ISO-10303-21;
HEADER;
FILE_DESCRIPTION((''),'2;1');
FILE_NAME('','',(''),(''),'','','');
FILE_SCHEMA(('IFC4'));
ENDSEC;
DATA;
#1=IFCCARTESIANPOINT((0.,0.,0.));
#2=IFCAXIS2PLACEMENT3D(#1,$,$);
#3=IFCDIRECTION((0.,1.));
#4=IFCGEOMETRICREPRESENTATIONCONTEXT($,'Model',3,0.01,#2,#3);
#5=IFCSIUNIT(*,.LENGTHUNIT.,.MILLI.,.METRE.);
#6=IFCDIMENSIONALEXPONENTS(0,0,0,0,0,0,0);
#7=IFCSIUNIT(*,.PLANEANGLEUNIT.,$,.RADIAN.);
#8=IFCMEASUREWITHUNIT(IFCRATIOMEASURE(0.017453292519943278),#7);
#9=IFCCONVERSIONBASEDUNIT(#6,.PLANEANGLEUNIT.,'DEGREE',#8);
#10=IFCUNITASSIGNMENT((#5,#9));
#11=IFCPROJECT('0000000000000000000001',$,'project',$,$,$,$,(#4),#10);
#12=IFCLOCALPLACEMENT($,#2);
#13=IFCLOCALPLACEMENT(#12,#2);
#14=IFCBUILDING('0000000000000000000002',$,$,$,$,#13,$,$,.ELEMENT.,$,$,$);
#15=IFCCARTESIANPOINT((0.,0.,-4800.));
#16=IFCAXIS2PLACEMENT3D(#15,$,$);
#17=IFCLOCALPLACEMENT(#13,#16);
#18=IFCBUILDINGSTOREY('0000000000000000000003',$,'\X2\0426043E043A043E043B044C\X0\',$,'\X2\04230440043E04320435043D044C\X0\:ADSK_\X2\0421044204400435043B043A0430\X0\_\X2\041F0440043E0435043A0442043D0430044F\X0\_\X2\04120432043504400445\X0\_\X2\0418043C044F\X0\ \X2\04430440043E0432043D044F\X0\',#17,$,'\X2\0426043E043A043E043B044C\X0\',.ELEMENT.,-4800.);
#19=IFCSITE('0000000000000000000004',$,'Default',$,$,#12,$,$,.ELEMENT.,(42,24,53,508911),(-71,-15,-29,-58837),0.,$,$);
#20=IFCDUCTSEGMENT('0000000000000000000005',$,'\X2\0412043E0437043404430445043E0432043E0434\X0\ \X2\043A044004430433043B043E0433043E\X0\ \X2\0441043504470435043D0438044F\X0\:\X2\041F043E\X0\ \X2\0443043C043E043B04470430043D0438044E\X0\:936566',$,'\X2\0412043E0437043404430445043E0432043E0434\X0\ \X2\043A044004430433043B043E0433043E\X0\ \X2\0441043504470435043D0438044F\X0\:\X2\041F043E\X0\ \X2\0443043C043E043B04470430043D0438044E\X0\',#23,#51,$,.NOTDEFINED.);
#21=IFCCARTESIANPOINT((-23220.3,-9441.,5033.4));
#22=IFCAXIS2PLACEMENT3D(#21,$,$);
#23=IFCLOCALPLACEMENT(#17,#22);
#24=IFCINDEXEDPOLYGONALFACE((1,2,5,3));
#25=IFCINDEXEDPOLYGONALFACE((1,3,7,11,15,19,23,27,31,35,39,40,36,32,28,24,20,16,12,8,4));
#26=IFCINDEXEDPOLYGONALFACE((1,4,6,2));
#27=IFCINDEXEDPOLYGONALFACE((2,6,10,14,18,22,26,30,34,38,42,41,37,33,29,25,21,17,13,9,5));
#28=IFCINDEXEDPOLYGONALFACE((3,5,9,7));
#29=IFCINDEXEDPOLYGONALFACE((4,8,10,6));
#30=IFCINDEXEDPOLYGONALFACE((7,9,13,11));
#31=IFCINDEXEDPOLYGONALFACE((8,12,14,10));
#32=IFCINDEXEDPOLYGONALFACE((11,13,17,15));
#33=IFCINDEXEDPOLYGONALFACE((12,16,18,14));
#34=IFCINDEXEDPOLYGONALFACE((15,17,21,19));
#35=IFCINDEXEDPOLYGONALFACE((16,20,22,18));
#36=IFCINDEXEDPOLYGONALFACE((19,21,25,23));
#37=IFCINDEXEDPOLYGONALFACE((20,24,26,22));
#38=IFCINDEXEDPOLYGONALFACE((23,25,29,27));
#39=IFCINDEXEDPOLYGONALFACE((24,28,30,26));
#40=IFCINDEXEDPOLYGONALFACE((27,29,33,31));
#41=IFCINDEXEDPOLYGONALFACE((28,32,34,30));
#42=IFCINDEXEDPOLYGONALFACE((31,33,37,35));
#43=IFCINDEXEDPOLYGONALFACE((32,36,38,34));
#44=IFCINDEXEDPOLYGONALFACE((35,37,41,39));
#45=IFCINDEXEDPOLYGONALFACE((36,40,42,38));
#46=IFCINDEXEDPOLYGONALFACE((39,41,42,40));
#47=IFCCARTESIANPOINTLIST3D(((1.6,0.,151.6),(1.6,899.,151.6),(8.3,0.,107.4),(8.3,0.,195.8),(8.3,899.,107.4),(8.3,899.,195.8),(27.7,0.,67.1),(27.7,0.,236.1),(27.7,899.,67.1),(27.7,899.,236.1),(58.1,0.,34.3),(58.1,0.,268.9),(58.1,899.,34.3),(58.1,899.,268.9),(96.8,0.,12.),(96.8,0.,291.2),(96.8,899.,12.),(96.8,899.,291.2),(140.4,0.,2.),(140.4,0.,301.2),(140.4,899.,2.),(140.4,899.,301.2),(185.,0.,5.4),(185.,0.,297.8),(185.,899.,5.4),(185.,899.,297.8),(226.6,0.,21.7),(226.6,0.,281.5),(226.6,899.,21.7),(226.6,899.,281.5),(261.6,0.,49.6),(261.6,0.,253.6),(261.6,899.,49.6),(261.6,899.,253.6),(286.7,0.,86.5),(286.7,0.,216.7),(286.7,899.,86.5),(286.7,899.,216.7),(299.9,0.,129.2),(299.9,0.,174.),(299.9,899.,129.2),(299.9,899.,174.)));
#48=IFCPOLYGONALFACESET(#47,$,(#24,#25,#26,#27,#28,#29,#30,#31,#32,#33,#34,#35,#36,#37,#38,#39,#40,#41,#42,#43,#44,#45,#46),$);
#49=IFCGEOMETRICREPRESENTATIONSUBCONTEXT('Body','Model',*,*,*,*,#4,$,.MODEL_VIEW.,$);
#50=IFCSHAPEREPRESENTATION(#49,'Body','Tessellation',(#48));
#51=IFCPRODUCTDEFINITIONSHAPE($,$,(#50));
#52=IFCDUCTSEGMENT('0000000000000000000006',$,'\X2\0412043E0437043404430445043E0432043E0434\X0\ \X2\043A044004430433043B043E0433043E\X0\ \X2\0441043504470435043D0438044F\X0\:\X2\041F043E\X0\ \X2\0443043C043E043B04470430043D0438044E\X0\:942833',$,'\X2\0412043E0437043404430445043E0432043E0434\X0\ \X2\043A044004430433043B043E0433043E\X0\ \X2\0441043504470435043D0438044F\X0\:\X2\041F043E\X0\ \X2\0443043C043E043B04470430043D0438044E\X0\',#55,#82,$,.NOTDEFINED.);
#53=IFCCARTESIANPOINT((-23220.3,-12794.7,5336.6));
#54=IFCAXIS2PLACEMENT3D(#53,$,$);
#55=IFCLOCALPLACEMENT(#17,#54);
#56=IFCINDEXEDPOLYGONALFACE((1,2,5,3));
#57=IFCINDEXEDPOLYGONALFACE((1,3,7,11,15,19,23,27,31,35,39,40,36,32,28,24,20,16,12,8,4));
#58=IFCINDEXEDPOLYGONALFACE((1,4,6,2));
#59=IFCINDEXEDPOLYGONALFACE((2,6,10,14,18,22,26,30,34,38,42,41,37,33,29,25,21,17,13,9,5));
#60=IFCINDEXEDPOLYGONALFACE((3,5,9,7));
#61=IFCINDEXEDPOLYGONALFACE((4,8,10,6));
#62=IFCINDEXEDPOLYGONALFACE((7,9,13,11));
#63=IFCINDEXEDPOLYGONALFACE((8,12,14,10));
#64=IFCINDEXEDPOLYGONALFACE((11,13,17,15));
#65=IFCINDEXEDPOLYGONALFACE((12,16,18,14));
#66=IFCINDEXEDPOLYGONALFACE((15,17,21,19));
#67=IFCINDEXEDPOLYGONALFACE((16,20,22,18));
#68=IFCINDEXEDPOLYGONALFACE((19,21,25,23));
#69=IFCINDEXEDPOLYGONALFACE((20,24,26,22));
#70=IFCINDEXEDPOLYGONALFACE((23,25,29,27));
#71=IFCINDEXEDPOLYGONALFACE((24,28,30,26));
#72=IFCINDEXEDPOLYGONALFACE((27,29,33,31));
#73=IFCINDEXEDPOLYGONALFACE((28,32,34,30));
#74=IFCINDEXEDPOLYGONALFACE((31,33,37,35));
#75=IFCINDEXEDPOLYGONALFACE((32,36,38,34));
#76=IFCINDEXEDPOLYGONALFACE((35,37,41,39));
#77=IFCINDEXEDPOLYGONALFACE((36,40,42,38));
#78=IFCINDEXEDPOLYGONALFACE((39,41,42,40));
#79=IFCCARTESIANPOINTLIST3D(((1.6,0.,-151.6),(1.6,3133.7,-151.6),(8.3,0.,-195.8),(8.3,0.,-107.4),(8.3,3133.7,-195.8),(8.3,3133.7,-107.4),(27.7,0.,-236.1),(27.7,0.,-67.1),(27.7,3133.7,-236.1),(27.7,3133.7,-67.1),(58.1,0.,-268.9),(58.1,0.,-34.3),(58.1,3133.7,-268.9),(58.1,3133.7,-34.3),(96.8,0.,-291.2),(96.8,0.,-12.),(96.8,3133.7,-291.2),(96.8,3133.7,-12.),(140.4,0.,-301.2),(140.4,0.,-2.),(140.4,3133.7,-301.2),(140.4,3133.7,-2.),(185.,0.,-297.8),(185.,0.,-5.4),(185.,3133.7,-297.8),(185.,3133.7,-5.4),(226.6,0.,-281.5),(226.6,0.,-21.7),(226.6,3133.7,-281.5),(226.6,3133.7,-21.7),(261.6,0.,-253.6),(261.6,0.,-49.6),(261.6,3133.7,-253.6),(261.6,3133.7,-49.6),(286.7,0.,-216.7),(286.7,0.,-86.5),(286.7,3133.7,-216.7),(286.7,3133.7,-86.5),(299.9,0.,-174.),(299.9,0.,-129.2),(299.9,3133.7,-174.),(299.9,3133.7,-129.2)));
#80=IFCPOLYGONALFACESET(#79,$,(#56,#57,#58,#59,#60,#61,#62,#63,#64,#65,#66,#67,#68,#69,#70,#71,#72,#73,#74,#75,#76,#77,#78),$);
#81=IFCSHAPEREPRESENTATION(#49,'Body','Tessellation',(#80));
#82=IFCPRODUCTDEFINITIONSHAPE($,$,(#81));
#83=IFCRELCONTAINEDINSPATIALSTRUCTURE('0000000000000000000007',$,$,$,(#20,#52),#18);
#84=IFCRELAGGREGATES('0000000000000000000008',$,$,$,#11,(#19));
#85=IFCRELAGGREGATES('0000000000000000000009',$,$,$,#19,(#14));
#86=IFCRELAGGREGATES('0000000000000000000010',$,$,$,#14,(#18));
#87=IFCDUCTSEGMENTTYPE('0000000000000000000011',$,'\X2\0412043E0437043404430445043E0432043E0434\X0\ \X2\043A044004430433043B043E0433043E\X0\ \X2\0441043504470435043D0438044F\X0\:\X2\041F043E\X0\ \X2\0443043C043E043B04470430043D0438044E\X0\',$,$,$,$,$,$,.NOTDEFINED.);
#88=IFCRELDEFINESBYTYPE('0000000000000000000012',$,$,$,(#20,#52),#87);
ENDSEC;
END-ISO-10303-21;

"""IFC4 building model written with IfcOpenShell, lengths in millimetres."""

from ifc_helpers import new_model, entity, si_unit, converted_unit, direction, frame, frame_2d, origin, place, context, subcontext, project, spatial, circle, extrude, type_object, element, save


model = new_model("IFC4")

# Units and contexts
model_context = context("Model", 3, precision=0.01, world=origin(), true_north=direction((0.0, 1.0)))
body_context = subcontext(model_context, "Body", "Model", "MODEL_VIEW")
ifc_project = project(units=[si_unit("LENGTHUNIT", "METRE", prefix="MILLI"), converted_unit("PLANEANGLEUNIT", "DEGREE", entity("IfcRatioMeasure", 0.017453292519943278), si_unit("PLANEANGLEUNIT", "RADIAN"), dimensions=[0, 0, 0, 0, 0, 0, 0])], contexts=[model_context])

# Site, building, storey
site_placement = place(None, origin())
site = spatial("IfcSite", under=ifc_project, at=site_placement, Name="Default", CompositionType="ELEMENT", RefLatitude=(42, 24, 53, 508911), RefLongitude=(-71, -15, -29, -58837), RefElevation=0.0)
building_placement = place(site_placement, origin())
building = spatial("IfcBuilding", under=site, at=building_placement, CompositionType="ELEMENT")
storey_placement = place(building_placement, frame((0.0, 0.0, -4800.0)))
storey = spatial("IfcBuildingStorey", under=building, at=storey_placement, Name="Цоколь", ObjectType="Уровень:ADSK_Стрелка_Проектная_Вверх_Имя уровня", LongName="Цоколь", CompositionType="ELEMENT", Elevation=-4800.0)

# Duct segments
duct_segment_type = type_object("IfcDuctSegmentType", Name="Воздуховод круглого сечения:По умолчанию", PredefinedType="NOTDEFINED")
duct_segment_1_placement = place(storey_placement, frame((-23220.3, -9441.0, 5033.4)))
element("IfcDuctSegment", 1, at=duct_segment_1_placement, inside=storey, type_object=duct_segment_type, Name="Воздуховод круглого сечения:По умолчанию:936566", ObjectType="Воздуховод круглого сечения:По умолчанию", PredefinedType="NOTDEFINED", context=body_context, shape_type="SweptSolid", body=[
    extrude(circle(Radius=150.0, at=frame_2d((0.0, 0.0), x_axis=(1.0, 0.0))), frame((151.6, 0.0, 151.6), z_axis=(0.0, 1.0, 0.0), x_axis=(-1.0, 0.0, 0.0)), (0.0, 0.0, 1.0), 899.0),
])
duct_segment_2_placement = place(storey_placement, frame((-23220.3, -12794.7, 5336.6)))
element("IfcDuctSegment", 2, at=duct_segment_2_placement, inside=storey, type_object=duct_segment_type, Name="Воздуховод круглого сечения:По умолчанию:942833", ObjectType="Воздуховод круглого сечения:По умолчанию", PredefinedType="NOTDEFINED", context=body_context, shape_type="SweptSolid", body=[
    extrude(circle(Radius=150.0, at=frame_2d((0.0, 0.0), x_axis=(1.0, 0.0))), frame((151.6, 0.0, -151.6), z_axis=(0.0, 1.0, 0.0), x_axis=(-1.0, 0.0, 0.0)), (0.0, 0.0, 1.0), 3133.7),
])

save(model, "model.ifc")
